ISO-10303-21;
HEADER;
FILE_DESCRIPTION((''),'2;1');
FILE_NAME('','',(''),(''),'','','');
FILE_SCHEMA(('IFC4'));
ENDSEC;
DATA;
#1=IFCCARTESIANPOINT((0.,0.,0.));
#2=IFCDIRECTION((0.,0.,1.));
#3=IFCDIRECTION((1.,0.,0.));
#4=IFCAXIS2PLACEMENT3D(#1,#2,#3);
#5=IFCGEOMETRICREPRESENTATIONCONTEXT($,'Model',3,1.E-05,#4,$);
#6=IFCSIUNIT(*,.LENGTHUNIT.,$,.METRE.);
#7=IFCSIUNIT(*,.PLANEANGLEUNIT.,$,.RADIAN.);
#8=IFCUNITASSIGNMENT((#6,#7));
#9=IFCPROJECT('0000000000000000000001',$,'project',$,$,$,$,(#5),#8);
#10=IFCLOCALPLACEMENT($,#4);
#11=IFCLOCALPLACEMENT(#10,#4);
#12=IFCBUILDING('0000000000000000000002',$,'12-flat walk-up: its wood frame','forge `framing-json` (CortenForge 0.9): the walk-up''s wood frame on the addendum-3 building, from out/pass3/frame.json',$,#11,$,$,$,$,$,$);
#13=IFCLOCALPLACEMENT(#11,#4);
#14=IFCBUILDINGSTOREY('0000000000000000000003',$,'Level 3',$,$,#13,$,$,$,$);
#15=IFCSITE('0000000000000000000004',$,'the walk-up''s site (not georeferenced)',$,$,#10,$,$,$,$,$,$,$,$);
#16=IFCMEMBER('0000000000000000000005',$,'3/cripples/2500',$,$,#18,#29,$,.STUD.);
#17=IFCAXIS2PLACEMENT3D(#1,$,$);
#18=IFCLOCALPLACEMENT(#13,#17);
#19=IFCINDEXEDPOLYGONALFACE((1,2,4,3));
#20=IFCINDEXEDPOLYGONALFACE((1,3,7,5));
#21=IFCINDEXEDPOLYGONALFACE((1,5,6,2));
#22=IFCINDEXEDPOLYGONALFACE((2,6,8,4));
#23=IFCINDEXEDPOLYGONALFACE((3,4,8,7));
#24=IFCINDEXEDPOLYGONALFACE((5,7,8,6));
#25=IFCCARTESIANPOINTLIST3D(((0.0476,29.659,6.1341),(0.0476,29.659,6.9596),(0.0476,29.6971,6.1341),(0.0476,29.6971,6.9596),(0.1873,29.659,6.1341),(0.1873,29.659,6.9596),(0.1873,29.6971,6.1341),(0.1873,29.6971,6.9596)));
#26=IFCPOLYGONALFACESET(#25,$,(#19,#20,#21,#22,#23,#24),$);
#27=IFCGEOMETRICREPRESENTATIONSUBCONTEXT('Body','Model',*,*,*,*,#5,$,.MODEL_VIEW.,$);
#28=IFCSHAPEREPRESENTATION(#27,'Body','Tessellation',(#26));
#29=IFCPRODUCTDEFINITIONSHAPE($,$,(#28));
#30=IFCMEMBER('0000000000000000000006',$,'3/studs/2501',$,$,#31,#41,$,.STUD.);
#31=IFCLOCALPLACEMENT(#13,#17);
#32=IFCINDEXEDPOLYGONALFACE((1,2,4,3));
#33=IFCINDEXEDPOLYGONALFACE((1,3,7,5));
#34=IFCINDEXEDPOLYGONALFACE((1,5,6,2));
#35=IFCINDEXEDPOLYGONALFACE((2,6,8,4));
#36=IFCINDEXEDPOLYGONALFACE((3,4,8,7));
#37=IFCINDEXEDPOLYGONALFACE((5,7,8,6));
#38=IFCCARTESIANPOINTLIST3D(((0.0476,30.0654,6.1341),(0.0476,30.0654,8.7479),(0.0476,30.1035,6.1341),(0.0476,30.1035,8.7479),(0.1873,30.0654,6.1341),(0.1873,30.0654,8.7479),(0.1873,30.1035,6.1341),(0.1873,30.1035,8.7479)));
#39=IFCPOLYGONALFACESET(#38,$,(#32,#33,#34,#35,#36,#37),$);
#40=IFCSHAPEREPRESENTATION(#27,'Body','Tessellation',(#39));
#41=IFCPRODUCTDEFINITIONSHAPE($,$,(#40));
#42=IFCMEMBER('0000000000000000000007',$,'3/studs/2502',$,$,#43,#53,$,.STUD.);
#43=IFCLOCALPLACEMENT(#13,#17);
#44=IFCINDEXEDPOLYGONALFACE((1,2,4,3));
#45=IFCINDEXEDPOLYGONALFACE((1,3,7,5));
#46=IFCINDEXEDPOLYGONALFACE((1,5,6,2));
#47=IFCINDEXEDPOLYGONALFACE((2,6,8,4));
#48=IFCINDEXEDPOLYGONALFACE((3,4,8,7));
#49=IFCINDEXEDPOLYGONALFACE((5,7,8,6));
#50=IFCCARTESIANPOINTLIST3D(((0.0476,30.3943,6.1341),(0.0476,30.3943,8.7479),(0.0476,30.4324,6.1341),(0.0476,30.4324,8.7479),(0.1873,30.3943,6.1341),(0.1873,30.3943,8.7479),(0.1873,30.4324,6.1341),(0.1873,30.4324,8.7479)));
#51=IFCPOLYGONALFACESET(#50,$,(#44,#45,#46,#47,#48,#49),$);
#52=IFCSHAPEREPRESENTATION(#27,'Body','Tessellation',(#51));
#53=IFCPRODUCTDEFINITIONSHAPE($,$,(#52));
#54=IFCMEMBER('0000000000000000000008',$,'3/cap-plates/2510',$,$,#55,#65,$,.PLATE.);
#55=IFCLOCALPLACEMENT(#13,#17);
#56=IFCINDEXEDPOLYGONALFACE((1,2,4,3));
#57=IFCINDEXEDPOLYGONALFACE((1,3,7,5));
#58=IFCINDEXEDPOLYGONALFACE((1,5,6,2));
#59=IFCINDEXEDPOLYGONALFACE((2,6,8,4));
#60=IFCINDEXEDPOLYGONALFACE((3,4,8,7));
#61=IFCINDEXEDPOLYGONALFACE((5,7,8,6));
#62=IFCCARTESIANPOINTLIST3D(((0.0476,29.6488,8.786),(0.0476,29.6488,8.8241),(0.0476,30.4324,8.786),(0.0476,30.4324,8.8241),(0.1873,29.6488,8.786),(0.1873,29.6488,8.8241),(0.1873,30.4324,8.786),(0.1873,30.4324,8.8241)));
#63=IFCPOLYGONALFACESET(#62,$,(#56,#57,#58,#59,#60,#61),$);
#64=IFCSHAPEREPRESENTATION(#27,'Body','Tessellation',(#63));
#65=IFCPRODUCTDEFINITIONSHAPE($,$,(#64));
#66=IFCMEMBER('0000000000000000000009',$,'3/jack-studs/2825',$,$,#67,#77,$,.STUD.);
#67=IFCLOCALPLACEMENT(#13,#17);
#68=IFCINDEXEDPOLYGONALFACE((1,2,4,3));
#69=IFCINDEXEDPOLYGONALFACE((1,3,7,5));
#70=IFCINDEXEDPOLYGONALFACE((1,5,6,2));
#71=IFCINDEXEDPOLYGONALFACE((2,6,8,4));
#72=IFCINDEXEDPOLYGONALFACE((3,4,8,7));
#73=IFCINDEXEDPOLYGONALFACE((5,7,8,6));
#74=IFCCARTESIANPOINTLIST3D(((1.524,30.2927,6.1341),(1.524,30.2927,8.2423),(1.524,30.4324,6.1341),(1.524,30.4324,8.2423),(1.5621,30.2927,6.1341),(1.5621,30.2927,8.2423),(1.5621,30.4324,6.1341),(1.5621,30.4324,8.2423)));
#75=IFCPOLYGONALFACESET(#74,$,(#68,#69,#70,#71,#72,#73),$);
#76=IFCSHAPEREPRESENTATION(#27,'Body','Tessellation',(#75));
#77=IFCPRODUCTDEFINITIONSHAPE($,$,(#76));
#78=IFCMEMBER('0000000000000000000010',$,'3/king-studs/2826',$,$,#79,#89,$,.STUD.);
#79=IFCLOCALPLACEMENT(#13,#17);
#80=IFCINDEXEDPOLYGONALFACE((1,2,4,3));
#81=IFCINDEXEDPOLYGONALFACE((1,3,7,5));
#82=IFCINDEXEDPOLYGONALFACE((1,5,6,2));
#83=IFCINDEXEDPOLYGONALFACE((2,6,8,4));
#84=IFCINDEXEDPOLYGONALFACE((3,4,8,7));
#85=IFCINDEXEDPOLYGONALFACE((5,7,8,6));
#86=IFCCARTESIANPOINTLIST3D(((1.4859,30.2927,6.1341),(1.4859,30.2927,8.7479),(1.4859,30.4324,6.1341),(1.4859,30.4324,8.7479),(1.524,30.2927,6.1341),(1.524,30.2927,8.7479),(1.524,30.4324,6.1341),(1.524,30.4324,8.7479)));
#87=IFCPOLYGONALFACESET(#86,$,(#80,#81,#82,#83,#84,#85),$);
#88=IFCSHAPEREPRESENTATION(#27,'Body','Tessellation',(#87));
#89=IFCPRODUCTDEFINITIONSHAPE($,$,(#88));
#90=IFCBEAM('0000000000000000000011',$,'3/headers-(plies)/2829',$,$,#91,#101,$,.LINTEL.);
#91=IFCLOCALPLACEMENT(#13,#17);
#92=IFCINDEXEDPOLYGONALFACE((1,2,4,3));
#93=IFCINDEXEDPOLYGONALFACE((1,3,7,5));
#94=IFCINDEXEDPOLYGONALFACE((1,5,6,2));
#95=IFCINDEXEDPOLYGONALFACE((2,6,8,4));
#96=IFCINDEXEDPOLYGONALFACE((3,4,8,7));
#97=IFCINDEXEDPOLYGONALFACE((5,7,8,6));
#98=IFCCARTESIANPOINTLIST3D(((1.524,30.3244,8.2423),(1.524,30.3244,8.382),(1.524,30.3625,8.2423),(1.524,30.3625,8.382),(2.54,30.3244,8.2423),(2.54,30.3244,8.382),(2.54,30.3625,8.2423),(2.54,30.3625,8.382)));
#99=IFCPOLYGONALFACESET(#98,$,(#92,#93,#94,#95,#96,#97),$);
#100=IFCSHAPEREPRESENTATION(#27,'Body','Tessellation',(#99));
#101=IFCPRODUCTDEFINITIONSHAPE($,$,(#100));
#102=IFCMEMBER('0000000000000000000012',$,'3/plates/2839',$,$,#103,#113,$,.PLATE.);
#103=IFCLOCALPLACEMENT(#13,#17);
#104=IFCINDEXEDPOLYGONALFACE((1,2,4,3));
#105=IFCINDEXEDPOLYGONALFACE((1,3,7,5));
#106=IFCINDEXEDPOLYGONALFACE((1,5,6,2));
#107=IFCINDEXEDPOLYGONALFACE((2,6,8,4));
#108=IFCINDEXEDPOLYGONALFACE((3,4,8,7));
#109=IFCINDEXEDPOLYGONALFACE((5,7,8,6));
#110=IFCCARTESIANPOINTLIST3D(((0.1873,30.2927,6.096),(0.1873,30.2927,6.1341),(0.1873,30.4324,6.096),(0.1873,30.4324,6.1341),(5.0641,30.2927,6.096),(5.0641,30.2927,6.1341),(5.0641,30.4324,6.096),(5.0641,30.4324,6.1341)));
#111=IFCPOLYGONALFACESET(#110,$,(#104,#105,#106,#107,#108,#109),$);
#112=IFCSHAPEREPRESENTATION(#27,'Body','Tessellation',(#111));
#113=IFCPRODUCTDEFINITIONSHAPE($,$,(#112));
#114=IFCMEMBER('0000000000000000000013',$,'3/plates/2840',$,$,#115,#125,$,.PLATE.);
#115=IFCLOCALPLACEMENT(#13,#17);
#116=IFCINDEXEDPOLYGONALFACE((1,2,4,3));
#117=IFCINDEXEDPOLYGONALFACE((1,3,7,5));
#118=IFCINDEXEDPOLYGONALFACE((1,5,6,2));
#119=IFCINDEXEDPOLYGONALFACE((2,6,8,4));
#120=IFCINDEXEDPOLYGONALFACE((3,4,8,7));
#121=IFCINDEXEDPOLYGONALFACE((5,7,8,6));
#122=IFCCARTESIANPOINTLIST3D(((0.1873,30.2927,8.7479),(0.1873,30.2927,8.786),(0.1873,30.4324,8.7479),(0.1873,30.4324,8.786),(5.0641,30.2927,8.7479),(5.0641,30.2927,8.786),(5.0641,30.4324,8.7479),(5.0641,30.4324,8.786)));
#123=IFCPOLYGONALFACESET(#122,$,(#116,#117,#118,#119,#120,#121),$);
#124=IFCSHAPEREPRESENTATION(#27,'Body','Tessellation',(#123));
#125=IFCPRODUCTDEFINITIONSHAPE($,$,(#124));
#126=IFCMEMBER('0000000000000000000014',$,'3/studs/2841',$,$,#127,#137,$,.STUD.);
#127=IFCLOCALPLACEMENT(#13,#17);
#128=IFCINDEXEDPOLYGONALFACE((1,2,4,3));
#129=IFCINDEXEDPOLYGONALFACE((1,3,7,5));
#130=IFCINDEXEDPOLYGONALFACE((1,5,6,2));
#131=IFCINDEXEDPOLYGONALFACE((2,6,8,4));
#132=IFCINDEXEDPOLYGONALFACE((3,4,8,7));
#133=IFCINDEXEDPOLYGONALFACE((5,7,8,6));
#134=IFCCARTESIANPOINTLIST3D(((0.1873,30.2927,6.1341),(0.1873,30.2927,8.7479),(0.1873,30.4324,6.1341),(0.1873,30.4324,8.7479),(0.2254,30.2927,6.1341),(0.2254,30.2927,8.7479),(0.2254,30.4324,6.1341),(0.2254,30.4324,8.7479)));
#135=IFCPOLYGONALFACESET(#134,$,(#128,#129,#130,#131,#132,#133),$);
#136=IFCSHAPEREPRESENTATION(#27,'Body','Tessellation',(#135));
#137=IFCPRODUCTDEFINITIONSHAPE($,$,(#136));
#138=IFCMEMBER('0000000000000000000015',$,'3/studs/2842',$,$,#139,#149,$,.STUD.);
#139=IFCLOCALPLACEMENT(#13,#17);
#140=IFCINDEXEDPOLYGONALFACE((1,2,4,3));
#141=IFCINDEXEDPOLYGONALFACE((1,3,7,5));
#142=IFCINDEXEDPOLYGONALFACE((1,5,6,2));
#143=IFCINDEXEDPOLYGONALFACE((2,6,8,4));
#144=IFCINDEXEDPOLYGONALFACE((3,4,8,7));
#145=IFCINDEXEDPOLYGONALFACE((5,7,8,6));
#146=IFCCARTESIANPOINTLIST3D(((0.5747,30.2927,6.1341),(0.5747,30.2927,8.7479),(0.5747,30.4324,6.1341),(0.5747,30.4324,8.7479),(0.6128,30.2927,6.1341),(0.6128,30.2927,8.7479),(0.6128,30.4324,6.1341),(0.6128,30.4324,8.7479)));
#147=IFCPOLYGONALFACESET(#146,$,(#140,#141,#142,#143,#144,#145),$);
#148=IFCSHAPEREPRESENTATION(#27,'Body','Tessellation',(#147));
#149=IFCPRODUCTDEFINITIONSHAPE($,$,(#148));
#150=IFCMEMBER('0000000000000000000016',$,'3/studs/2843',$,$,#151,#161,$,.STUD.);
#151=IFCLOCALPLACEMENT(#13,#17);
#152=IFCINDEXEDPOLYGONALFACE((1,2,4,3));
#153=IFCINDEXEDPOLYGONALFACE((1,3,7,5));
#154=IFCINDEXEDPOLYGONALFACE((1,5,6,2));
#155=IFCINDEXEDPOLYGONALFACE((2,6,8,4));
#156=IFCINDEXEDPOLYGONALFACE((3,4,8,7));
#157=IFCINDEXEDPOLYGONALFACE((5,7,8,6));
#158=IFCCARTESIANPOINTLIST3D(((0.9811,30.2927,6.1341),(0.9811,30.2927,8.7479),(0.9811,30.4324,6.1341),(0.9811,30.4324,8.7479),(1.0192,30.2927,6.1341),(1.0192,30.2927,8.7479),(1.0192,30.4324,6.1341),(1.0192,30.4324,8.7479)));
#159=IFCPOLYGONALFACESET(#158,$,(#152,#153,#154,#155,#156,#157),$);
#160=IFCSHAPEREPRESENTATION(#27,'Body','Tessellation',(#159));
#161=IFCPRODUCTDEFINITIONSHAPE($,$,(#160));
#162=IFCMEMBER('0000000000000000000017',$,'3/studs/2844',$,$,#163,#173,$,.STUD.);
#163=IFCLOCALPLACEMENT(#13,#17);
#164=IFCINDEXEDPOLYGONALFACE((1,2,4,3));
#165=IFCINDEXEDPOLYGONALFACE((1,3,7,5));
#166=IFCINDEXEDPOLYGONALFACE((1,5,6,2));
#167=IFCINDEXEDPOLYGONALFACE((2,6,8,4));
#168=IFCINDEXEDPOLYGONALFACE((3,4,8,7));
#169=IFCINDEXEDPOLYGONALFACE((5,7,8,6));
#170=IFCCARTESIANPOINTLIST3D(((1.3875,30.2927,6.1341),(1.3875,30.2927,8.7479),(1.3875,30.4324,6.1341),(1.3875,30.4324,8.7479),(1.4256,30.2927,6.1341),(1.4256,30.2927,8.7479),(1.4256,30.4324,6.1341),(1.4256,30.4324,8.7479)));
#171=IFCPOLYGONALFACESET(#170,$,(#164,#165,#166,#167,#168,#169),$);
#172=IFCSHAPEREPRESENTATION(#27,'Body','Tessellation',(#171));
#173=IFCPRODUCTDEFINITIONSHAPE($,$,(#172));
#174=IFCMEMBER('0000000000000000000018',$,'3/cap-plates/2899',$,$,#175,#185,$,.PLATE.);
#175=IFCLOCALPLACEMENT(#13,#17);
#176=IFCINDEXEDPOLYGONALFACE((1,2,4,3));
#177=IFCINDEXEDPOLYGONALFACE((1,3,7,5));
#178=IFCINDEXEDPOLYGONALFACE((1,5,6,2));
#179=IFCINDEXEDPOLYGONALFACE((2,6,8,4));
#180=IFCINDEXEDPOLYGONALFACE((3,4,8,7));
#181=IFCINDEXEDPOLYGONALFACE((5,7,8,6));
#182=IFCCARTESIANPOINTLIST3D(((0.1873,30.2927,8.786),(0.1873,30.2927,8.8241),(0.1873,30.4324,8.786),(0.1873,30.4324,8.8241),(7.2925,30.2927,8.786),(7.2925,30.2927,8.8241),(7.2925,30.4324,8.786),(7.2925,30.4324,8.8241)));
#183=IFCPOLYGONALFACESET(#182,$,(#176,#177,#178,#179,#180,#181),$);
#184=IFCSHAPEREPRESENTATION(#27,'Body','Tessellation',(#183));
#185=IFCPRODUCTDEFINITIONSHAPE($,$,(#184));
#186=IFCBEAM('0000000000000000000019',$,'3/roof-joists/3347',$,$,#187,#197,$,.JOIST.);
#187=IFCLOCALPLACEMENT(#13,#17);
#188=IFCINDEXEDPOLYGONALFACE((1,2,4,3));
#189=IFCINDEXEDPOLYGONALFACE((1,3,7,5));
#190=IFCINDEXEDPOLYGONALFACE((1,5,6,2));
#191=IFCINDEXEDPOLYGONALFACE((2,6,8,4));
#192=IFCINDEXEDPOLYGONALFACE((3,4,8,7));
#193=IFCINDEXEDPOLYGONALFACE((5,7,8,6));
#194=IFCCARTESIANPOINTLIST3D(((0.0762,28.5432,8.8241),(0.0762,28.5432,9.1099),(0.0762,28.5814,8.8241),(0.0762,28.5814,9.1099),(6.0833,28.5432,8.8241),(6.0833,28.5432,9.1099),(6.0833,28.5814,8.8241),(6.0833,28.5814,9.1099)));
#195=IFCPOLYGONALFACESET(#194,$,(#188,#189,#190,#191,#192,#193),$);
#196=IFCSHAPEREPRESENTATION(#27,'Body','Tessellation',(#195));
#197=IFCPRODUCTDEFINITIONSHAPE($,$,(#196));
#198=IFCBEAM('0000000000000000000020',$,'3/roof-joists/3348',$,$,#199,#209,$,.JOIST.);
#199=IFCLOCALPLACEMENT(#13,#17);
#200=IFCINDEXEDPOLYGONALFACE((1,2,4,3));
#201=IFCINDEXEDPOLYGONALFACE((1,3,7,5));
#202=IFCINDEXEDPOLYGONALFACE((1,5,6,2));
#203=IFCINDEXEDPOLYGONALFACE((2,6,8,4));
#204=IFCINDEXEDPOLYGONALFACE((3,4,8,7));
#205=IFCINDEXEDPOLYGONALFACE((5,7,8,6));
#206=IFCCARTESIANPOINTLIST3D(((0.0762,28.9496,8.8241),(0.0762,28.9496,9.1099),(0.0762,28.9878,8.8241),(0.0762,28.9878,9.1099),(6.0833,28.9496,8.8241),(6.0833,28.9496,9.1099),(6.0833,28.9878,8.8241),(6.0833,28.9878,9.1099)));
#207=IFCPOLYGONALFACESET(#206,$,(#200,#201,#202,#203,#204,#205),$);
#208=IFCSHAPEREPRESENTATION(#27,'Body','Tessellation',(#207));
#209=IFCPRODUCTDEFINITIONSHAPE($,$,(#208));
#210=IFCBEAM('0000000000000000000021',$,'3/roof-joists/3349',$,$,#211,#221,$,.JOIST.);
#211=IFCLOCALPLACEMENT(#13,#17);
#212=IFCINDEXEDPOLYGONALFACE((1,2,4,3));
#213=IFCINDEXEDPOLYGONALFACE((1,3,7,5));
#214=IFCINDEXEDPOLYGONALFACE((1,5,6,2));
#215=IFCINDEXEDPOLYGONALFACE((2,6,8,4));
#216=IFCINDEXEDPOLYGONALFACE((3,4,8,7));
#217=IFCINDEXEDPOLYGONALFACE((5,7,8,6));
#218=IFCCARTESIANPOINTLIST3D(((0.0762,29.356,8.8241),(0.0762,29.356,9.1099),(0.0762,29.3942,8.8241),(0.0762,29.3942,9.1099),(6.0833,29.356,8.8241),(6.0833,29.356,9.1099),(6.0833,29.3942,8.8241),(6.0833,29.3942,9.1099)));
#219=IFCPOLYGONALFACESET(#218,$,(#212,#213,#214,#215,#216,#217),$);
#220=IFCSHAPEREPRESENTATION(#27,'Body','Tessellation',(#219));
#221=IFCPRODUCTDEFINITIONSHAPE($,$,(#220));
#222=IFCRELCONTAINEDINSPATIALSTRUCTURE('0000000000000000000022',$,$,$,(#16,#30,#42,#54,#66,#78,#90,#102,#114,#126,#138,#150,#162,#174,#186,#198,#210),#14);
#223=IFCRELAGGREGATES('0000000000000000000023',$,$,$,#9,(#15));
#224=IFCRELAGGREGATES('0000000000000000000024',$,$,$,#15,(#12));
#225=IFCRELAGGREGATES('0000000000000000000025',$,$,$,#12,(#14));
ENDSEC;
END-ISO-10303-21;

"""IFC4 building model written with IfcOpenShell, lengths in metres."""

from ifc_helpers import new_model, si_unit, frame, frame_2d, origin, origin_with_axes, place, context, subcontext, project, spatial, rectangle, extrude, element, save


model = new_model("IFC4")

# Units and contexts
model_context = context("Model", 3, precision=1e-05, world=origin_with_axes())
body_context = subcontext(model_context, "Body", "Model", "MODEL_VIEW")
ifc_project = project(units=[si_unit("LENGTHUNIT", "METRE"), si_unit("PLANEANGLEUNIT", "RADIAN")], contexts=[model_context])

# Site, building, storey
site_placement = place(None, origin_with_axes())
site = spatial("IfcSite", under=ifc_project, at=site_placement, Name="the walk-up's site (not georeferenced)")
building_placement = place(site_placement, origin_with_axes())
building = spatial("IfcBuilding", under=site, at=building_placement, Name="12-flat walk-up: its wood frame", Description="forge `framing-json` (CortenForge 0.9): the walk-up's wood frame on the addendum-3 building, from out/pass3/frame.json")
storey_placement = place(building_placement, origin_with_axes())
storey = spatial("IfcBuildingStorey", under=building, at=storey_placement, Name="Level 3")

# Members
member_1_placement = place(storey_placement, frame((0.0476, 29.659, 6.1341), z_axis=(0.0, 0.0, 1.0), x_axis=(1.0, 0.0, 0.0)))
element("IfcMember", 1, at=member_1_placement, inside=storey, Name="3/cripples/2500", PredefinedType="STUD", context=body_context, shape_type="SweptSolid", body=[
    extrude(rectangle(XDim=0.1397, YDim=0.0381, at=frame_2d((0.0698, 0.0191))), origin(), (0.0, 0.0, 1.0), 0.8255),
])
for number, where, z_axis, x_axis, name in (
    (2, (0.0476, 30.0654, 6.1341), (0.0, 0.0, 1.0), (1.0, 0.0, 0.0), "3/studs/2501"),
    (3, (0.0476, 30.3943, 6.1341), (0.0, 0.0, 1.0), (1.0, 0.0, 0.0), "3/studs/2502"),
):
    element("IfcMember", number, at=place(storey_placement, frame(where, z_axis=z_axis, x_axis=x_axis)), inside=storey, Name=name, PredefinedType="STUD", context=body_context, shape_type="SweptSolid", body=[
        extrude(rectangle(XDim=0.1397, YDim=0.0381, at=frame_2d((0.0698, 0.0191))), origin(), (0.0, 0.0, 1.0), 2.6138),
    ])
member_2_placement = place(storey_placement, frame((0.0476, 29.6488, 8.786), z_axis=(0.0, 0.0, 1.0), x_axis=(1.0, 0.0, 0.0)))
element("IfcMember", 4, at=member_2_placement, inside=storey, Name="3/cap-plates/2510", PredefinedType="PLATE", context=body_context, shape_type="SweptSolid", body=[
    extrude(rectangle(XDim=0.1397, YDim=0.7836, at=frame_2d((0.0698, 0.3918))), origin(), (0.0, 0.0, 1.0), 0.0381),
])
member_3_placement = place(storey_placement, frame((1.524, 30.2927, 6.1341), z_axis=(0.0, 0.0, 1.0), x_axis=(1.0, 0.0, 0.0)))
element("IfcMember", 5, at=member_3_placement, inside=storey, Name="3/jack-studs/2825", PredefinedType="STUD", context=body_context, shape_type="SweptSolid", body=[
    extrude(rectangle(XDim=0.0381, YDim=0.1397, at=frame_2d((0.0191, 0.0699))), origin(), (0.0, 0.0, 1.0), 2.1082),
])
member_4_placement = place(storey_placement, frame((1.4859, 30.2927, 6.1341), z_axis=(0.0, 0.0, 1.0), x_axis=(1.0, 0.0, 0.0)))
element("IfcMember", 6, at=member_4_placement, inside=storey, Name="3/king-studs/2826", PredefinedType="STUD", context=body_context, shape_type="SweptSolid", body=[
    extrude(rectangle(XDim=0.0381, YDim=0.1397, at=frame_2d((0.0191, 0.0699))), origin(), (0.0, 0.0, 1.0), 2.6138),
])

# Beam
beam_placement = place(storey_placement, frame((1.524, 30.3244, 8.2423), z_axis=(0.0, 0.0, 1.0), x_axis=(1.0, 0.0, 0.0)))
element("IfcBeam", 7, at=beam_placement, inside=storey, Name="3/headers-(plies)/2829", PredefinedType="LINTEL", context=body_context, shape_type="SweptSolid", body=[
    extrude(rectangle(XDim=1.016, YDim=0.0381, at=frame_2d((0.508, 0.0191))), origin(), (0.0, 0.0, 1.0), 0.1397),
])

# Members
for number, where, z_axis, x_axis, name in (
    (8, (0.1873, 30.2927, 6.096), (0.0, 0.0, 1.0), (1.0, 0.0, 0.0), "3/plates/2839"),
    (9, (0.1873, 30.2927, 8.7479), (0.0, 0.0, 1.0), (1.0, 0.0, 0.0), "3/plates/2840"),
):
    element("IfcMember", number, at=place(storey_placement, frame(where, z_axis=z_axis, x_axis=x_axis)), inside=storey, Name=name, PredefinedType="PLATE", context=body_context, shape_type="SweptSolid", body=[
        extrude(rectangle(XDim=4.8768, YDim=0.1397, at=frame_2d((2.4384, 0.0699))), origin(), (0.0, 0.0, 1.0), 0.0381),
    ])
member_5_placement = place(storey_placement, frame((0.1873, 30.2927, 6.1341), z_axis=(0.0, 0.0, 1.0), x_axis=(1.0, 0.0, 0.0)))
element("IfcMember", 10, at=member_5_placement, inside=storey, Name="3/studs/2841", PredefinedType="STUD", context=body_context, shape_type="SweptSolid", body=[
    extrude(rectangle(XDim=0.0381, YDim=0.1397, at=frame_2d((0.019, 0.0699))), origin(), (0.0, 0.0, 1.0), 2.6138),
])
for number, where, z_axis, x_axis, name in (
    (11, (0.5747, 30.2927, 6.1341), (0.0, 0.0, 1.0), (1.0, 0.0, 0.0), "3/studs/2842"),
    (12, (0.9811, 30.2927, 6.1341), (0.0, 0.0, 1.0), (1.0, 0.0, 0.0), "3/studs/2843"),
):
    element("IfcMember", number, at=place(storey_placement, frame(where, z_axis=z_axis, x_axis=x_axis)), inside=storey, Name=name, PredefinedType="STUD", context=body_context, shape_type="SweptSolid", body=[
        extrude(rectangle(XDim=0.0381, YDim=0.1397, at=frame_2d((0.019, 0.0699))), origin(), (0.0, 0.0, 1.0), 2.6138),
    ])
member_6_placement = place(storey_placement, frame((1.3875, 30.2927, 6.1341), z_axis=(0.0, 0.0, 1.0), x_axis=(1.0, 0.0, 0.0)))
element("IfcMember", 13, at=member_6_placement, inside=storey, Name="3/studs/2844", PredefinedType="STUD", context=body_context, shape_type="SweptSolid", body=[
    extrude(rectangle(XDim=0.0381, YDim=0.1397, at=frame_2d((0.0191, 0.0699))), origin(), (0.0, 0.0, 1.0), 2.6138),
])
member_7_placement = place(storey_placement, frame((0.1873, 30.2927, 8.786), z_axis=(0.0, 0.0, 1.0), x_axis=(1.0, 0.0, 0.0)))
element("IfcMember", 14, at=member_7_placement, inside=storey, Name="3/cap-plates/2899", PredefinedType="PLATE", context=body_context, shape_type="SweptSolid", body=[
    extrude(rectangle(XDim=7.1052, YDim=0.1397, at=frame_2d((3.5526, 0.0699))), origin(), (0.0, 0.0, 1.0), 0.0381),
])

# Beams
for number, where, z_axis, x_axis, name in (
    (15, (0.0762, 28.5433, 8.8241), (0.0, 0.0, 1.0), (1.0, 0.0, 0.0), "3/roof-joists/3347"),
    (16, (0.0762, 28.9496, 8.8241), (0.0, 0.0, 1.0), (1.0, 0.0, 0.0), "3/roof-joists/3348"),
    (17, (0.0762, 29.356, 8.8241), (0.0, 0.0, 1.0), (1.0, 0.0, 0.0), "3/roof-joists/3349"),
):
    element("IfcBeam", number, at=place(storey_placement, frame(where, z_axis=z_axis, x_axis=x_axis)), inside=storey, Name=name, PredefinedType="JOIST", context=body_context, shape_type="SweptSolid", body=[
        extrude(rectangle(XDim=6.0071, YDim=0.0381, at=frame_2d((3.0036, 0.0191))), origin(), (0.0, 0.0, 1.0), 0.2858),
    ])

save(model, "model.ifc")
